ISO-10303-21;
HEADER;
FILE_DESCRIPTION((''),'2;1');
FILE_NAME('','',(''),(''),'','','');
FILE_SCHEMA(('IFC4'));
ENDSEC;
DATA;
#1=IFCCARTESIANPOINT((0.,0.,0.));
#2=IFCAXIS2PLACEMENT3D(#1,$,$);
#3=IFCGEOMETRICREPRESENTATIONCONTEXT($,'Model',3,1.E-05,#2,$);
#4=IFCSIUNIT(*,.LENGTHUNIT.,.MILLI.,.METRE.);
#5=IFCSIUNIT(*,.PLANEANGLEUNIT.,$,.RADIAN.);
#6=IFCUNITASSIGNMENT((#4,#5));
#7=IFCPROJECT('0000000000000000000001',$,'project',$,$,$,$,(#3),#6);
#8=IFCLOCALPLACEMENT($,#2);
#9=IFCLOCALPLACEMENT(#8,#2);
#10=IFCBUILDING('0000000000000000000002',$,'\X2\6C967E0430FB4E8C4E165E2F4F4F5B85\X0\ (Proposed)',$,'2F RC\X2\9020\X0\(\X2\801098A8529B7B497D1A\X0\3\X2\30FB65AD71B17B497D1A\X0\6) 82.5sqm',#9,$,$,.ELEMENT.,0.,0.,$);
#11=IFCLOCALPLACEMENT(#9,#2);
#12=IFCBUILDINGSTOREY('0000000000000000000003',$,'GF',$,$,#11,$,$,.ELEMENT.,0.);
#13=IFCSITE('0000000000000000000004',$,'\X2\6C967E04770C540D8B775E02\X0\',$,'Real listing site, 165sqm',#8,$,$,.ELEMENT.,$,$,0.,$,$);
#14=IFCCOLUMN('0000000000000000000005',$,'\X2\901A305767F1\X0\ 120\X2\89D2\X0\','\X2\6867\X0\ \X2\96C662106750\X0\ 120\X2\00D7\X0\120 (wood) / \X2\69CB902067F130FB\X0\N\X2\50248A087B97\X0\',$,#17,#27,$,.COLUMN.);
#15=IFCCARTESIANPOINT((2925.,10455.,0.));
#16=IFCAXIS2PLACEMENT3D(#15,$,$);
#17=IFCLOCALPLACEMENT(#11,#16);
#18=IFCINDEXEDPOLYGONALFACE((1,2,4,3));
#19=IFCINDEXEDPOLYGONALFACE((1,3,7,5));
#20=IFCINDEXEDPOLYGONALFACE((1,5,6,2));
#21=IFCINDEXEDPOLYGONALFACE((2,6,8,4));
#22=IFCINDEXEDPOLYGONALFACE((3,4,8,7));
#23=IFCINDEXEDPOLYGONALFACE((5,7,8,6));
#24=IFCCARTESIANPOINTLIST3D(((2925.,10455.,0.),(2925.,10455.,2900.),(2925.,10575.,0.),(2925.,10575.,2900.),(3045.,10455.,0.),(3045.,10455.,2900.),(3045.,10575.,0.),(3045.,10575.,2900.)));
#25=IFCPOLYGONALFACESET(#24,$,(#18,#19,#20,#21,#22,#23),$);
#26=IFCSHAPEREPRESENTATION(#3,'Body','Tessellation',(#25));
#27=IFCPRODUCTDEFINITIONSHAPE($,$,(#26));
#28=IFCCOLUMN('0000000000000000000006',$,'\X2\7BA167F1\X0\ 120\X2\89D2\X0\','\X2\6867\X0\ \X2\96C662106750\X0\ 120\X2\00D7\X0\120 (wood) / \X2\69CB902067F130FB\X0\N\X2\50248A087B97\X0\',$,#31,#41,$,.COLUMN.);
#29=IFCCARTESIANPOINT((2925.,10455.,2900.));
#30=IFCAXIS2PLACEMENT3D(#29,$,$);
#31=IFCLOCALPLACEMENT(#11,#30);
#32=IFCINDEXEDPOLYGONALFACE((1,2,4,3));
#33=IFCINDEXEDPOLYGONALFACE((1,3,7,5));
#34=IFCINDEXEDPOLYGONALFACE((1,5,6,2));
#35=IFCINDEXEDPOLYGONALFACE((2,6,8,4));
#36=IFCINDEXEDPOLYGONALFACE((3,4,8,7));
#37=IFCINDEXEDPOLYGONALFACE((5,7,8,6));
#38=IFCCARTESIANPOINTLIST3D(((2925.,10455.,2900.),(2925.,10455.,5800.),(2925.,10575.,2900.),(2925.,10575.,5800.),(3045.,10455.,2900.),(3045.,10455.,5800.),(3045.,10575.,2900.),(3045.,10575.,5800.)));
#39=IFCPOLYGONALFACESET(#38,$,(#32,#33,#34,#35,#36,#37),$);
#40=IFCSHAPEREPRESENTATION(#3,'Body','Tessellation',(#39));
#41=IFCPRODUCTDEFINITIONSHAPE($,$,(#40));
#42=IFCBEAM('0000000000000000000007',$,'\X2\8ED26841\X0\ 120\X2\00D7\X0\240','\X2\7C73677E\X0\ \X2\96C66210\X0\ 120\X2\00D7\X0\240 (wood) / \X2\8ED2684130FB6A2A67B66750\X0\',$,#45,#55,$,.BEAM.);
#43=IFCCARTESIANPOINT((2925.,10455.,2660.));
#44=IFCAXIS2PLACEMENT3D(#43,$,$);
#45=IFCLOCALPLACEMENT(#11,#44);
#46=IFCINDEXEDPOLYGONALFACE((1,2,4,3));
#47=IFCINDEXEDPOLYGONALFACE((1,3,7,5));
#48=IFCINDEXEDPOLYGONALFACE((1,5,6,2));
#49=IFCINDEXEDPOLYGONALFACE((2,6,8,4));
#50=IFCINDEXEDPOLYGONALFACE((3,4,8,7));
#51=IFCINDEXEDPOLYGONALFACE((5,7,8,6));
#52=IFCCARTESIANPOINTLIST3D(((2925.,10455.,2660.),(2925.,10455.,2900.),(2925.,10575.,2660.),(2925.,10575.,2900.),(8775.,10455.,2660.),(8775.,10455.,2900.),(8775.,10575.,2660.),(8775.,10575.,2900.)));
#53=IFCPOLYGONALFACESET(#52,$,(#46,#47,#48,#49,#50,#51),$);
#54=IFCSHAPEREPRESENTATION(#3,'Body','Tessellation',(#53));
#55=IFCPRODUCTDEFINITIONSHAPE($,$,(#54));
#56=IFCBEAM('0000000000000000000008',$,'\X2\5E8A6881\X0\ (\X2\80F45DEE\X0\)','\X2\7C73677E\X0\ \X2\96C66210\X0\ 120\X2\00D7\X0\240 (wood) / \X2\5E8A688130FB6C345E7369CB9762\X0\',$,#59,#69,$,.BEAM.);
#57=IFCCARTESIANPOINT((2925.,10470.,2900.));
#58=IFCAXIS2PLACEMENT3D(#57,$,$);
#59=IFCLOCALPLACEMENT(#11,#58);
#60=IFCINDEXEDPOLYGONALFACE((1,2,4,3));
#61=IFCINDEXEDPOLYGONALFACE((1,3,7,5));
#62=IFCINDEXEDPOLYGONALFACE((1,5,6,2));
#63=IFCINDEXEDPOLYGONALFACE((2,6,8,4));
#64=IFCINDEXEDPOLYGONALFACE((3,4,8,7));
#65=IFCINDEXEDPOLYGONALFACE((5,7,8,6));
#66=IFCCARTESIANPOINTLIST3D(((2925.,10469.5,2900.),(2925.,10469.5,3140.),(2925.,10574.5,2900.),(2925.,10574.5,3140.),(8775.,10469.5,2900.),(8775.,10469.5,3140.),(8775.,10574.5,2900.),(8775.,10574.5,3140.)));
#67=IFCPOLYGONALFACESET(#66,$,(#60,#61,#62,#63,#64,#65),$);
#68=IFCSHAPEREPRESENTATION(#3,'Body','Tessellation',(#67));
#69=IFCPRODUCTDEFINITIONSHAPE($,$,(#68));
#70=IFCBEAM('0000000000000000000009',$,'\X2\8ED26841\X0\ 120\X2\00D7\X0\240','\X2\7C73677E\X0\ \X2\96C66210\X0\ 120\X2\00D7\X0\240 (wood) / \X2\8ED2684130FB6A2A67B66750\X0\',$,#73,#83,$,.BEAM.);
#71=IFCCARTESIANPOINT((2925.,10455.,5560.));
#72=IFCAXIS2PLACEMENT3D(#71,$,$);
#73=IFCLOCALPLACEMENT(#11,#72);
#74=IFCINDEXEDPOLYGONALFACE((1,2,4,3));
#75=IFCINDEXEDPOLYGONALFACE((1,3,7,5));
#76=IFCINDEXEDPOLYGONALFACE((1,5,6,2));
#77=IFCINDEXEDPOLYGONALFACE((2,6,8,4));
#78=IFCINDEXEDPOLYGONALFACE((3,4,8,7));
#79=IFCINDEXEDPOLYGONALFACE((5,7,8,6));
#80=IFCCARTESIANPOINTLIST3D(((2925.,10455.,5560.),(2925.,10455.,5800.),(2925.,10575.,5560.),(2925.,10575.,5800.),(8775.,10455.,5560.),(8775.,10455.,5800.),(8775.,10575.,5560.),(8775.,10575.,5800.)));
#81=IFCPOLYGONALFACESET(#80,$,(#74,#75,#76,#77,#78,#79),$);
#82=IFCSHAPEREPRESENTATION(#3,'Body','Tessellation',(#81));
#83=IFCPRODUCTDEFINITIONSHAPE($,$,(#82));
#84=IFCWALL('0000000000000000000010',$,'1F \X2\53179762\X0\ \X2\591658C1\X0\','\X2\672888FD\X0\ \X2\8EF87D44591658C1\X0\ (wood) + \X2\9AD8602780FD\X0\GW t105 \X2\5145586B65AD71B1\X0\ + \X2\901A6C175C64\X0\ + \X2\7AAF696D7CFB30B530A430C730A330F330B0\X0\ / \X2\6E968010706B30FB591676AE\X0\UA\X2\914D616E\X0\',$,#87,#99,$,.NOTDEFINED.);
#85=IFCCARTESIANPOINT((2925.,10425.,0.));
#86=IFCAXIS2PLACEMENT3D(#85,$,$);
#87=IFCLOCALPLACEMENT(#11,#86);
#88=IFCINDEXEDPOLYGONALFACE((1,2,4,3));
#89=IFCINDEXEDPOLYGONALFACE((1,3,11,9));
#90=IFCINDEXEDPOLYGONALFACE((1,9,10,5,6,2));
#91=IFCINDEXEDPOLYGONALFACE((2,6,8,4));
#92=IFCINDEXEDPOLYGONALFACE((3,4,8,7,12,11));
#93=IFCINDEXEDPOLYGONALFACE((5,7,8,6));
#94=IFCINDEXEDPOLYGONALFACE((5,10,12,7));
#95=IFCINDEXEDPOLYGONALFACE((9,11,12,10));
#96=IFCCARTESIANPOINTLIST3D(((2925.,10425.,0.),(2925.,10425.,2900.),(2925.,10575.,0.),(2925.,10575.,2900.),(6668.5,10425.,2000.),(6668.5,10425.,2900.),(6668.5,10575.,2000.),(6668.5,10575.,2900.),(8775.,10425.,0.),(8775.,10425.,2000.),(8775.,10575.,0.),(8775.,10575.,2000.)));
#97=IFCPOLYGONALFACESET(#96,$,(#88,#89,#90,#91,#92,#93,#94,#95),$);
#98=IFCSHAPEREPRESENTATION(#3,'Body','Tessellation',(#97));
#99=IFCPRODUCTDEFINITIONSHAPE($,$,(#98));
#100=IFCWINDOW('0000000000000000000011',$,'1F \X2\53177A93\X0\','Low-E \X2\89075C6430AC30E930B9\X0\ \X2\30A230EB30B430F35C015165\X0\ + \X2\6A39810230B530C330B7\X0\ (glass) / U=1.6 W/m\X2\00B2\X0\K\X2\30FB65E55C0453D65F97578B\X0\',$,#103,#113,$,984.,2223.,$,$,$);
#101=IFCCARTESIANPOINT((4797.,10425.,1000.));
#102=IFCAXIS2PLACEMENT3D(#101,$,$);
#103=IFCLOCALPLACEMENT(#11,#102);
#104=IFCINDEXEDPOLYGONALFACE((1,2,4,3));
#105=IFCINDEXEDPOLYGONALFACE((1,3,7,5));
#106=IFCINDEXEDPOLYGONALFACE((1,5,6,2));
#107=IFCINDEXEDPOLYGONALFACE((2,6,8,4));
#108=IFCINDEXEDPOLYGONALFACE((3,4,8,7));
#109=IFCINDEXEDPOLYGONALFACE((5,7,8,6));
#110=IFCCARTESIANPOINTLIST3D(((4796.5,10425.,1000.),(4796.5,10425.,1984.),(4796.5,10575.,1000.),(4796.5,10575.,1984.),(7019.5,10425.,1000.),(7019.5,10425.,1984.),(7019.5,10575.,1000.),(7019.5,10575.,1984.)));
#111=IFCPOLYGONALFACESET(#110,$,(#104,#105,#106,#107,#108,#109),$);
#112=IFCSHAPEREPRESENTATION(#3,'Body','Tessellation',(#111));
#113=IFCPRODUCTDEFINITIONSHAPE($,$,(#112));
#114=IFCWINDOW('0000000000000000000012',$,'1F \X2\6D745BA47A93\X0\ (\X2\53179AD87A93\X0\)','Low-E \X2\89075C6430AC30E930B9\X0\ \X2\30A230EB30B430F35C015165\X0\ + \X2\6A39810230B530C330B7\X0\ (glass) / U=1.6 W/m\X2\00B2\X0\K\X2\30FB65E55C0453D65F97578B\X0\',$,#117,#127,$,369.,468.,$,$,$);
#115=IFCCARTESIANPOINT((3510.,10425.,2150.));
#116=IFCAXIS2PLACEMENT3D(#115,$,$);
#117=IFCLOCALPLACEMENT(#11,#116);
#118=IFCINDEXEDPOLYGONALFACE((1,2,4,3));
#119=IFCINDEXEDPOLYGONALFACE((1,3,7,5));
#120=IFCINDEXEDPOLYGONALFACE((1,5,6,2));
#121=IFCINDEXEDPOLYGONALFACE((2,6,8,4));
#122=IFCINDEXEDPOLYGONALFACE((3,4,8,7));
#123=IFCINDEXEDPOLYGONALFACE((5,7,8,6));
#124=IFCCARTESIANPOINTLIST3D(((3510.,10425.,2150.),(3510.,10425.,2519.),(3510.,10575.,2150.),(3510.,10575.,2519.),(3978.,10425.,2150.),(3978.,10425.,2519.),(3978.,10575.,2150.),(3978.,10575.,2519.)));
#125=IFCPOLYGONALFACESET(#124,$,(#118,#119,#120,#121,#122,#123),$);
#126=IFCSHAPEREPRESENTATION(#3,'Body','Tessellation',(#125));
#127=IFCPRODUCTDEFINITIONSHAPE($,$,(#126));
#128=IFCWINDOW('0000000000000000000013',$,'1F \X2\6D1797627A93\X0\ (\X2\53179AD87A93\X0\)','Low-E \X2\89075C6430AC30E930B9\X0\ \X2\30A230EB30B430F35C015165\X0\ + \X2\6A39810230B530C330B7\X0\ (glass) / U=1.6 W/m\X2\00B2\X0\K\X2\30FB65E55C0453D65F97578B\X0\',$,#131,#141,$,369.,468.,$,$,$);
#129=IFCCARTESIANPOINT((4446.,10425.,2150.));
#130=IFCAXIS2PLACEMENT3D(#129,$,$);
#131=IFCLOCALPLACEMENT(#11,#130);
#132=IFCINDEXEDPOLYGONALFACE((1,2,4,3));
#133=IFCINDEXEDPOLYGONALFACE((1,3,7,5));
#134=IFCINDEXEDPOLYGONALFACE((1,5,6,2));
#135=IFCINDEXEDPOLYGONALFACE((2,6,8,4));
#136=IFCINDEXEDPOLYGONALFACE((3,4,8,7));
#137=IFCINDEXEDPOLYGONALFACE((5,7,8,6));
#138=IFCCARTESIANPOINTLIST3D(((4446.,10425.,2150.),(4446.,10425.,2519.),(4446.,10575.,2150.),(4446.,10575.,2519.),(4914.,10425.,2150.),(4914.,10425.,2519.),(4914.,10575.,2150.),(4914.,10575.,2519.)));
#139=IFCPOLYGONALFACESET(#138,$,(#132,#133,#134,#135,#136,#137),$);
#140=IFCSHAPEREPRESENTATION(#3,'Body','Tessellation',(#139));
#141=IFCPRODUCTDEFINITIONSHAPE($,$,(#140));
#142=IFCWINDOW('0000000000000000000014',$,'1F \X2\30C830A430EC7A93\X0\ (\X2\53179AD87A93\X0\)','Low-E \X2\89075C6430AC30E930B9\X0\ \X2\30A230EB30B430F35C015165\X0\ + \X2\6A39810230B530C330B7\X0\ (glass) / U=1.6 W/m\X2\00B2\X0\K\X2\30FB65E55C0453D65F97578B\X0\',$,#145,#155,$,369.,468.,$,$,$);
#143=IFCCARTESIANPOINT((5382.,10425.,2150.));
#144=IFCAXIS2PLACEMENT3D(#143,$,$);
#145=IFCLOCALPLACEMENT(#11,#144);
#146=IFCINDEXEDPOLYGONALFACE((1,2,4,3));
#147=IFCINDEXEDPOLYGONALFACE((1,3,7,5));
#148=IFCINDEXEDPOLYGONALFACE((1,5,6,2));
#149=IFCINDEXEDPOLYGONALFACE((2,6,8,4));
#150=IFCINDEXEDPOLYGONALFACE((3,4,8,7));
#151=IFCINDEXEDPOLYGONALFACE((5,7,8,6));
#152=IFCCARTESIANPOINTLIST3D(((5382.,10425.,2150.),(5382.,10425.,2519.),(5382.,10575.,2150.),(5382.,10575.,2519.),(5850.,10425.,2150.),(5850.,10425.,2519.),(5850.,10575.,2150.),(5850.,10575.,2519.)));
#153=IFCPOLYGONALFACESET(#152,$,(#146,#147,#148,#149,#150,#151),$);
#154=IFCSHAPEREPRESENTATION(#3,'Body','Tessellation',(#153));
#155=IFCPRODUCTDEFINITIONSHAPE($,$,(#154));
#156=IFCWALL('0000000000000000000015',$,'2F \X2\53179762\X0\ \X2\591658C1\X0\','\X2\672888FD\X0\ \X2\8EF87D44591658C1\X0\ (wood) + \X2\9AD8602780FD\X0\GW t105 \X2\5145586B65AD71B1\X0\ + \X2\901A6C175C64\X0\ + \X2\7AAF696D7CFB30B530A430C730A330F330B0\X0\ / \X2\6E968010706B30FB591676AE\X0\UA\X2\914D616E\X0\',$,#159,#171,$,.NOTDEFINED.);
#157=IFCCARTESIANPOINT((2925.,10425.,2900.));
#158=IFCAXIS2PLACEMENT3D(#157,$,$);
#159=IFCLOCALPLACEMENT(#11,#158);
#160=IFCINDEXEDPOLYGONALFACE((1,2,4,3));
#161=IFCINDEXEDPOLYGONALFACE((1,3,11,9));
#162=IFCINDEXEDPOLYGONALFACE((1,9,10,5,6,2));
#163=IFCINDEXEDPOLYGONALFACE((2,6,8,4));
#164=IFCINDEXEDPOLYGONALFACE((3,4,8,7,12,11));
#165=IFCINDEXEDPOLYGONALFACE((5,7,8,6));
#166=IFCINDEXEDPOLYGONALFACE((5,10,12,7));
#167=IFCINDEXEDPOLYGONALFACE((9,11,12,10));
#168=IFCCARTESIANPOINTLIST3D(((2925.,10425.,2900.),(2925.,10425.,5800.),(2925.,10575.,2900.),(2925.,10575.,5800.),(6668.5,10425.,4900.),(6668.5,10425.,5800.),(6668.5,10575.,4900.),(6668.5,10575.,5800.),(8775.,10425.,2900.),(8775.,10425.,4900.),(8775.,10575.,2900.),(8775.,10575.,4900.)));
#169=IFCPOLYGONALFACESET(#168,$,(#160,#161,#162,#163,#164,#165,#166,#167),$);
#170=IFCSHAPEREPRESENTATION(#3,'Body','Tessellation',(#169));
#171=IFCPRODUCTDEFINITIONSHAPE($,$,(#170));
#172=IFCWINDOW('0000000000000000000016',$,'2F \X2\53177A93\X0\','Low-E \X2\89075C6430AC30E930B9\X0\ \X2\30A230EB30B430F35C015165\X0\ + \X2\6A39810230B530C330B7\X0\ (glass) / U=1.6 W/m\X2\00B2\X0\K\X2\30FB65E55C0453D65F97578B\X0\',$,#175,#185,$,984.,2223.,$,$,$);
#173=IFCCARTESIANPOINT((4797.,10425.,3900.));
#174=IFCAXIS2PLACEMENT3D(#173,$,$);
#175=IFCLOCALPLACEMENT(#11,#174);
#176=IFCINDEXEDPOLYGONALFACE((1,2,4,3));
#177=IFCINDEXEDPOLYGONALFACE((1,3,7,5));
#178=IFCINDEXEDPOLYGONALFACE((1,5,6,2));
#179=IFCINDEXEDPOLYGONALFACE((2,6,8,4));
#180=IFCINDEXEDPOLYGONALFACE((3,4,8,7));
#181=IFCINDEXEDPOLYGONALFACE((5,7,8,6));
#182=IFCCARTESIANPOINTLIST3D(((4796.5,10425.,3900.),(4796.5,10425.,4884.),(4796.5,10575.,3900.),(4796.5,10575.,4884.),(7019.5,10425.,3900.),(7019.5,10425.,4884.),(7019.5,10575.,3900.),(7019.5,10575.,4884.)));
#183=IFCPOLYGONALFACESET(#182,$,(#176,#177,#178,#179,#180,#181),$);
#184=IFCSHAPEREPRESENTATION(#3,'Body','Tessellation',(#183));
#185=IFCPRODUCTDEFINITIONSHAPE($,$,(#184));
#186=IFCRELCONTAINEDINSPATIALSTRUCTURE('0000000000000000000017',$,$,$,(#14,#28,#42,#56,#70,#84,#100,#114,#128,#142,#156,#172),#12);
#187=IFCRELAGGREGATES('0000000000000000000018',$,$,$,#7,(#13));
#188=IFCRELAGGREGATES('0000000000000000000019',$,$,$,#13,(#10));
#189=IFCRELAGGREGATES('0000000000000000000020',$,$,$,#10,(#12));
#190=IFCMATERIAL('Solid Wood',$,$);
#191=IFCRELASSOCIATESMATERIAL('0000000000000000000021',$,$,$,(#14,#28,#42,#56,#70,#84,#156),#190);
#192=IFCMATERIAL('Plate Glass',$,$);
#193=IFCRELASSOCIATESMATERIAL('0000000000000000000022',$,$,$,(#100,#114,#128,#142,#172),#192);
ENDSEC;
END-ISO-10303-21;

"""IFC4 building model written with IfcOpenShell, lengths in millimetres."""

from ifc_helpers import new_model, si_unit, frame, frame_2d, origin, place, context, project, spatial, rectangle, extrude, material, element, fill, save


model = new_model("IFC4")

# Units and contexts
model_context = context("Model", 3, precision=1e-05, world=origin())
ifc_project = project(units=[si_unit("LENGTHUNIT", "METRE", prefix="MILLI"), si_unit("PLANEANGLEUNIT", "RADIAN")], contexts=[model_context])

# Site, building, storey
site_placement = place(None, origin())
site = spatial("IfcSite", under=ifc_project, at=site_placement, Name="沖縄県名護市", ObjectType="Real listing site, 165sqm", CompositionType="ELEMENT", RefElevation=0.0)
building_placement = place(site_placement, origin())
building = spatial("IfcBuilding", under=site, at=building_placement, Name="沖縄・二世帯住宅 (Proposed)", ObjectType="2F RC造(耐風力等級3・断熱等級6) 82.5sqm", CompositionType="ELEMENT", ElevationOfRefHeight=0.0, ElevationOfTerrain=0.0)
storey_placement = place(building_placement, origin())
storey = spatial("IfcBuildingStorey", under=building, at=storey_placement, Name="GF", CompositionType="ELEMENT", Elevation=0.0)

# Columns
ifc_material_1 = material(Name="Solid Wood")
column_1_placement = place(storey_placement, frame((2925.0, 10455.0, 0.0)))
element("IfcColumn", 1, at=column_1_placement, inside=storey, material=ifc_material_1, Name="通し柱 120角", Description="桧 集成材 120×120 (wood) / 構造柱・N値計算", PredefinedType="COLUMN", context=model_context, shape_type="SweptSolid", body=[
    extrude(rectangle(XDim=120.0, YDim=120.0, at=frame_2d((60.0, 60.0))), frame((2925.0, 10455.0, 0.0)), (0.0, 0.0, 1.0), 2900.0),
])
column_2_placement = place(storey_placement, frame((2925.0, 10455.0, 2900.0)))
element("IfcColumn", 2, at=column_2_placement, inside=storey, material=ifc_material_1, Name="管柱 120角", Description="桧 集成材 120×120 (wood) / 構造柱・N値計算", PredefinedType="COLUMN", context=model_context, shape_type="SweptSolid", body=[
    extrude(rectangle(XDim=120.0, YDim=120.0, at=frame_2d((60.0, 60.0))), frame((2925.0, 10455.0, 2900.0)), (0.0, 0.0, 1.0), 2900.0),
])

# Beams
beam_1_placement = place(storey_placement, frame((2925.0, 10455.0, 2660.0)))
element("IfcBeam", 3, at=beam_1_placement, inside=storey, material=ifc_material_1, Name="軒桁 120×240", Description="米松 集成 120×240 (wood) / 軒桁・横架材", PredefinedType="BEAM", context=model_context, shape_type="SweptSolid", body=[
    extrude(rectangle(XDim=5850.0, YDim=120.0, at=frame_2d((2925.0, 60.0))), frame((2925.0, 10455.0, 2660.0)), (0.0, 0.0, 1.0), 240.0),
])
beam_2_placement = place(storey_placement, frame((2925.0, 10470.0, 2900.0)))
element("IfcBeam", 4, at=beam_2_placement, inside=storey, material=ifc_material_1, Name="床梁 (胴差)", Description="米松 集成 120×240 (wood) / 床梁・水平構面", PredefinedType="BEAM", context=model_context, shape_type="SweptSolid", body=[
    extrude(rectangle(XDim=5850.0, YDim=105.0, at=frame_2d((2925.0, 52.0))), frame((2925.0, 10470.0, 2900.0)), (0.0, 0.0, 1.0), 240.0),
])
beam_3_placement = place(storey_placement, frame((2925.0, 10455.0, 5560.0)))
element("IfcBeam", 5, at=beam_3_placement, inside=storey, material=ifc_material_1, Name="軒桁 120×240", Description="米松 集成 120×240 (wood) / 軒桁・横架材", PredefinedType="BEAM", context=model_context, shape_type="SweptSolid", body=[
    extrude(rectangle(XDim=5850.0, YDim=120.0, at=frame_2d((2925.0, 60.0))), frame((2925.0, 10455.0, 5560.0)), (0.0, 0.0, 1.0), 240.0),
])

# Wall, openings, windows
wall_1_placement = place(storey_placement, frame((2925.0, 10425.0, 0.0)))
wall_1 = element("IfcWall", 6, at=wall_1_placement, inside=storey, material=ifc_material_1, Name="1F 北面 外壁", Description="木製 軸組外壁 (wood) + 高性能GW t105 充填断熱 + 通気層 + 窯業系サイディング / 準耐火・外皮UA配慮", PredefinedType="NOTDEFINED", context=model_context, shape_type="SweptSolid", body=[
    extrude(rectangle(XDim=5850.0, YDim=150.0, at=frame_2d((2925.0, 75.0))), frame((2925.0, 10425.0, 0.0)), (0.0, 0.0, 1.0), 2900.0),
])
opening_1_placement = place(storey_placement, frame((4797.0, 10425.0, 1000.0)))
opening_1 = element("IfcOpeningElement", 7, at=opening_1_placement, cuts=wall_1, PredefinedType="NOTDEFINED", context=model_context, shape_type="SweptSolid", body=[
    extrude(rectangle(XDim=2223.0, YDim=150.0, at=frame_2d((1111.0, 75.0))), frame((4797.0, 10425.0, 1000.0)), (0.0, 0.0, 1.0), 984.0),
])
opening_2_placement = place(storey_placement, frame((3510.0, 10425.0, 2150.0)))
opening_2 = element("IfcOpeningElement", 8, at=opening_2_placement, cuts=wall_1, PredefinedType="NOTDEFINED", context=model_context, shape_type="SweptSolid", body=[
    extrude(rectangle(XDim=468.0, YDim=150.0, at=frame_2d((234.0, 75.0))), frame((3510.0, 10425.0, 2150.0)), (0.0, 0.0, 1.0), 369.0),
])
opening_3_placement = place(storey_placement, frame((4446.0, 10425.0, 2150.0)))
opening_3 = element("IfcOpeningElement", 9, at=opening_3_placement, cuts=wall_1, PredefinedType="NOTDEFINED", context=model_context, shape_type="SweptSolid", body=[
    extrude(rectangle(XDim=468.0, YDim=150.0, at=frame_2d((234.0, 75.0))), frame((4446.0, 10425.0, 2150.0)), (0.0, 0.0, 1.0), 369.0),
])
opening_4_placement = place(storey_placement, frame((5382.0, 10425.0, 2150.0)))
opening_4 = element("IfcOpeningElement", 10, at=opening_4_placement, cuts=wall_1, PredefinedType="NOTDEFINED", context=model_context, shape_type="SweptSolid", body=[
    extrude(rectangle(XDim=468.0, YDim=150.0, at=frame_2d((234.0, 75.0))), frame((5382.0, 10425.0, 2150.0)), (0.0, 0.0, 1.0), 369.0),
])
ifc_material_2 = material(Name="Plate Glass")
window_1_placement = place(storey_placement, frame((4797.0, 10425.0, 1000.0)))
window_1 = element("IfcWindow", 11, at=window_1_placement, inside=storey, material=ifc_material_2, Name="1F 北窓", Description="Low-E 複層ガラス アルゴン封入 + 樹脂サッシ (glass) / U=1.6 W/m²K・日射取得型", OverallHeight=984.0, OverallWidth=2223.0, context=model_context, shape_type="SweptSolid", body=[
    extrude(rectangle(XDim=2223.0, YDim=150.0, at=frame_2d((1111.0, 75.0))), frame((4797.0, 10425.0, 1000.0)), (0.0, 0.0, 1.0), 984.0),
])
fill(opening_1, window_1)
window_2_placement = place(storey_placement, frame((3510.0, 10425.0, 2150.0)))
window_2 = element("IfcWindow", 12, at=window_2_placement, inside=storey, material=ifc_material_2, Name="1F 浴室窓 (北高窓)", Description="Low-E 複層ガラス アルゴン封入 + 樹脂サッシ (glass) / U=1.6 W/m²K・日射取得型", OverallHeight=369.0, OverallWidth=468.0, context=model_context, shape_type="SweptSolid", body=[
    extrude(rectangle(XDim=468.0, YDim=150.0, at=frame_2d((234.0, 75.0))), frame((3510.0, 10425.0, 2150.0)), (0.0, 0.0, 1.0), 369.0),
])
fill(opening_2, window_2)
window_3_placement = place(storey_placement, frame((4446.0, 10425.0, 2150.0)))
window_3 = element("IfcWindow", 13, at=window_3_placement, inside=storey, material=ifc_material_2, Name="1F 洗面窓 (北高窓)", Description="Low-E 複層ガラス アルゴン封入 + 樹脂サッシ (glass) / U=1.6 W/m²K・日射取得型", OverallHeight=369.0, OverallWidth=468.0, context=model_context, shape_type="SweptSolid", body=[
    extrude(rectangle(XDim=468.0, YDim=150.0, at=frame_2d((234.0, 75.0))), frame((4446.0, 10425.0, 2150.0)), (0.0, 0.0, 1.0), 369.0),
])
fill(opening_3, window_3)
window_4_placement = place(storey_placement, frame((5382.0, 10425.0, 2150.0)))
window_4 = element("IfcWindow", 14, at=window_4_placement, inside=storey, material=ifc_material_2, Name="1F トイレ窓 (北高窓)", Description="Low-E 複層ガラス アルゴン封入 + 樹脂サッシ (glass) / U=1.6 W/m²K・日射取得型", OverallHeight=369.0, OverallWidth=468.0, context=model_context, shape_type="SweptSolid", body=[
    extrude(rectangle(XDim=468.0, YDim=150.0, at=frame_2d((234.0, 75.0))), frame((5382.0, 10425.0, 2150.0)), (0.0, 0.0, 1.0), 369.0),
])
fill(opening_4, window_4)

# Wall, opening, window
wall_2_placement = place(storey_placement, frame((2925.0, 10425.0, 2900.0)))
wall_2 = element("IfcWall", 15, at=wall_2_placement, inside=storey, material=ifc_material_1, Name="2F 北面 外壁", Description="木製 軸組外壁 (wood) + 高性能GW t105 充填断熱 + 通気層 + 窯業系サイディング / 準耐火・外皮UA配慮", PredefinedType="NOTDEFINED", context=model_context, shape_type="SweptSolid", body=[
    extrude(rectangle(XDim=5850.0, YDim=150.0, at=frame_2d((2925.0, 75.0))), frame((2925.0, 10425.0, 2900.0)), (0.0, 0.0, 1.0), 2900.0),
])
opening_5_placement = place(storey_placement, frame((4797.0, 10425.0, 3900.0)))
opening_5 = element("IfcOpeningElement", 16, at=opening_5_placement, cuts=wall_2, PredefinedType="NOTDEFINED", context=model_context, shape_type="SweptSolid", body=[
    extrude(rectangle(XDim=2223.0, YDim=150.0, at=frame_2d((1111.0, 75.0))), frame((4797.0, 10425.0, 3900.0)), (0.0, 0.0, 1.0), 984.0),
])
window_5_placement = place(storey_placement, frame((4797.0, 10425.0, 3900.0)))
window_5 = element("IfcWindow", 17, at=window_5_placement, inside=storey, material=ifc_material_2, Name="2F 北窓", Description="Low-E 複層ガラス アルゴン封入 + 樹脂サッシ (glass) / U=1.6 W/m²K・日射取得型", OverallHeight=984.0, OverallWidth=2223.0, context=model_context, shape_type="SweptSolid", body=[
    extrude(rectangle(XDim=2223.0, YDim=150.0, at=frame_2d((1111.0, 75.0))), frame((4797.0, 10425.0, 3900.0)), (0.0, 0.0, 1.0), 984.0),
])
fill(opening_5, window_5)

save(model, "model.ifc")
